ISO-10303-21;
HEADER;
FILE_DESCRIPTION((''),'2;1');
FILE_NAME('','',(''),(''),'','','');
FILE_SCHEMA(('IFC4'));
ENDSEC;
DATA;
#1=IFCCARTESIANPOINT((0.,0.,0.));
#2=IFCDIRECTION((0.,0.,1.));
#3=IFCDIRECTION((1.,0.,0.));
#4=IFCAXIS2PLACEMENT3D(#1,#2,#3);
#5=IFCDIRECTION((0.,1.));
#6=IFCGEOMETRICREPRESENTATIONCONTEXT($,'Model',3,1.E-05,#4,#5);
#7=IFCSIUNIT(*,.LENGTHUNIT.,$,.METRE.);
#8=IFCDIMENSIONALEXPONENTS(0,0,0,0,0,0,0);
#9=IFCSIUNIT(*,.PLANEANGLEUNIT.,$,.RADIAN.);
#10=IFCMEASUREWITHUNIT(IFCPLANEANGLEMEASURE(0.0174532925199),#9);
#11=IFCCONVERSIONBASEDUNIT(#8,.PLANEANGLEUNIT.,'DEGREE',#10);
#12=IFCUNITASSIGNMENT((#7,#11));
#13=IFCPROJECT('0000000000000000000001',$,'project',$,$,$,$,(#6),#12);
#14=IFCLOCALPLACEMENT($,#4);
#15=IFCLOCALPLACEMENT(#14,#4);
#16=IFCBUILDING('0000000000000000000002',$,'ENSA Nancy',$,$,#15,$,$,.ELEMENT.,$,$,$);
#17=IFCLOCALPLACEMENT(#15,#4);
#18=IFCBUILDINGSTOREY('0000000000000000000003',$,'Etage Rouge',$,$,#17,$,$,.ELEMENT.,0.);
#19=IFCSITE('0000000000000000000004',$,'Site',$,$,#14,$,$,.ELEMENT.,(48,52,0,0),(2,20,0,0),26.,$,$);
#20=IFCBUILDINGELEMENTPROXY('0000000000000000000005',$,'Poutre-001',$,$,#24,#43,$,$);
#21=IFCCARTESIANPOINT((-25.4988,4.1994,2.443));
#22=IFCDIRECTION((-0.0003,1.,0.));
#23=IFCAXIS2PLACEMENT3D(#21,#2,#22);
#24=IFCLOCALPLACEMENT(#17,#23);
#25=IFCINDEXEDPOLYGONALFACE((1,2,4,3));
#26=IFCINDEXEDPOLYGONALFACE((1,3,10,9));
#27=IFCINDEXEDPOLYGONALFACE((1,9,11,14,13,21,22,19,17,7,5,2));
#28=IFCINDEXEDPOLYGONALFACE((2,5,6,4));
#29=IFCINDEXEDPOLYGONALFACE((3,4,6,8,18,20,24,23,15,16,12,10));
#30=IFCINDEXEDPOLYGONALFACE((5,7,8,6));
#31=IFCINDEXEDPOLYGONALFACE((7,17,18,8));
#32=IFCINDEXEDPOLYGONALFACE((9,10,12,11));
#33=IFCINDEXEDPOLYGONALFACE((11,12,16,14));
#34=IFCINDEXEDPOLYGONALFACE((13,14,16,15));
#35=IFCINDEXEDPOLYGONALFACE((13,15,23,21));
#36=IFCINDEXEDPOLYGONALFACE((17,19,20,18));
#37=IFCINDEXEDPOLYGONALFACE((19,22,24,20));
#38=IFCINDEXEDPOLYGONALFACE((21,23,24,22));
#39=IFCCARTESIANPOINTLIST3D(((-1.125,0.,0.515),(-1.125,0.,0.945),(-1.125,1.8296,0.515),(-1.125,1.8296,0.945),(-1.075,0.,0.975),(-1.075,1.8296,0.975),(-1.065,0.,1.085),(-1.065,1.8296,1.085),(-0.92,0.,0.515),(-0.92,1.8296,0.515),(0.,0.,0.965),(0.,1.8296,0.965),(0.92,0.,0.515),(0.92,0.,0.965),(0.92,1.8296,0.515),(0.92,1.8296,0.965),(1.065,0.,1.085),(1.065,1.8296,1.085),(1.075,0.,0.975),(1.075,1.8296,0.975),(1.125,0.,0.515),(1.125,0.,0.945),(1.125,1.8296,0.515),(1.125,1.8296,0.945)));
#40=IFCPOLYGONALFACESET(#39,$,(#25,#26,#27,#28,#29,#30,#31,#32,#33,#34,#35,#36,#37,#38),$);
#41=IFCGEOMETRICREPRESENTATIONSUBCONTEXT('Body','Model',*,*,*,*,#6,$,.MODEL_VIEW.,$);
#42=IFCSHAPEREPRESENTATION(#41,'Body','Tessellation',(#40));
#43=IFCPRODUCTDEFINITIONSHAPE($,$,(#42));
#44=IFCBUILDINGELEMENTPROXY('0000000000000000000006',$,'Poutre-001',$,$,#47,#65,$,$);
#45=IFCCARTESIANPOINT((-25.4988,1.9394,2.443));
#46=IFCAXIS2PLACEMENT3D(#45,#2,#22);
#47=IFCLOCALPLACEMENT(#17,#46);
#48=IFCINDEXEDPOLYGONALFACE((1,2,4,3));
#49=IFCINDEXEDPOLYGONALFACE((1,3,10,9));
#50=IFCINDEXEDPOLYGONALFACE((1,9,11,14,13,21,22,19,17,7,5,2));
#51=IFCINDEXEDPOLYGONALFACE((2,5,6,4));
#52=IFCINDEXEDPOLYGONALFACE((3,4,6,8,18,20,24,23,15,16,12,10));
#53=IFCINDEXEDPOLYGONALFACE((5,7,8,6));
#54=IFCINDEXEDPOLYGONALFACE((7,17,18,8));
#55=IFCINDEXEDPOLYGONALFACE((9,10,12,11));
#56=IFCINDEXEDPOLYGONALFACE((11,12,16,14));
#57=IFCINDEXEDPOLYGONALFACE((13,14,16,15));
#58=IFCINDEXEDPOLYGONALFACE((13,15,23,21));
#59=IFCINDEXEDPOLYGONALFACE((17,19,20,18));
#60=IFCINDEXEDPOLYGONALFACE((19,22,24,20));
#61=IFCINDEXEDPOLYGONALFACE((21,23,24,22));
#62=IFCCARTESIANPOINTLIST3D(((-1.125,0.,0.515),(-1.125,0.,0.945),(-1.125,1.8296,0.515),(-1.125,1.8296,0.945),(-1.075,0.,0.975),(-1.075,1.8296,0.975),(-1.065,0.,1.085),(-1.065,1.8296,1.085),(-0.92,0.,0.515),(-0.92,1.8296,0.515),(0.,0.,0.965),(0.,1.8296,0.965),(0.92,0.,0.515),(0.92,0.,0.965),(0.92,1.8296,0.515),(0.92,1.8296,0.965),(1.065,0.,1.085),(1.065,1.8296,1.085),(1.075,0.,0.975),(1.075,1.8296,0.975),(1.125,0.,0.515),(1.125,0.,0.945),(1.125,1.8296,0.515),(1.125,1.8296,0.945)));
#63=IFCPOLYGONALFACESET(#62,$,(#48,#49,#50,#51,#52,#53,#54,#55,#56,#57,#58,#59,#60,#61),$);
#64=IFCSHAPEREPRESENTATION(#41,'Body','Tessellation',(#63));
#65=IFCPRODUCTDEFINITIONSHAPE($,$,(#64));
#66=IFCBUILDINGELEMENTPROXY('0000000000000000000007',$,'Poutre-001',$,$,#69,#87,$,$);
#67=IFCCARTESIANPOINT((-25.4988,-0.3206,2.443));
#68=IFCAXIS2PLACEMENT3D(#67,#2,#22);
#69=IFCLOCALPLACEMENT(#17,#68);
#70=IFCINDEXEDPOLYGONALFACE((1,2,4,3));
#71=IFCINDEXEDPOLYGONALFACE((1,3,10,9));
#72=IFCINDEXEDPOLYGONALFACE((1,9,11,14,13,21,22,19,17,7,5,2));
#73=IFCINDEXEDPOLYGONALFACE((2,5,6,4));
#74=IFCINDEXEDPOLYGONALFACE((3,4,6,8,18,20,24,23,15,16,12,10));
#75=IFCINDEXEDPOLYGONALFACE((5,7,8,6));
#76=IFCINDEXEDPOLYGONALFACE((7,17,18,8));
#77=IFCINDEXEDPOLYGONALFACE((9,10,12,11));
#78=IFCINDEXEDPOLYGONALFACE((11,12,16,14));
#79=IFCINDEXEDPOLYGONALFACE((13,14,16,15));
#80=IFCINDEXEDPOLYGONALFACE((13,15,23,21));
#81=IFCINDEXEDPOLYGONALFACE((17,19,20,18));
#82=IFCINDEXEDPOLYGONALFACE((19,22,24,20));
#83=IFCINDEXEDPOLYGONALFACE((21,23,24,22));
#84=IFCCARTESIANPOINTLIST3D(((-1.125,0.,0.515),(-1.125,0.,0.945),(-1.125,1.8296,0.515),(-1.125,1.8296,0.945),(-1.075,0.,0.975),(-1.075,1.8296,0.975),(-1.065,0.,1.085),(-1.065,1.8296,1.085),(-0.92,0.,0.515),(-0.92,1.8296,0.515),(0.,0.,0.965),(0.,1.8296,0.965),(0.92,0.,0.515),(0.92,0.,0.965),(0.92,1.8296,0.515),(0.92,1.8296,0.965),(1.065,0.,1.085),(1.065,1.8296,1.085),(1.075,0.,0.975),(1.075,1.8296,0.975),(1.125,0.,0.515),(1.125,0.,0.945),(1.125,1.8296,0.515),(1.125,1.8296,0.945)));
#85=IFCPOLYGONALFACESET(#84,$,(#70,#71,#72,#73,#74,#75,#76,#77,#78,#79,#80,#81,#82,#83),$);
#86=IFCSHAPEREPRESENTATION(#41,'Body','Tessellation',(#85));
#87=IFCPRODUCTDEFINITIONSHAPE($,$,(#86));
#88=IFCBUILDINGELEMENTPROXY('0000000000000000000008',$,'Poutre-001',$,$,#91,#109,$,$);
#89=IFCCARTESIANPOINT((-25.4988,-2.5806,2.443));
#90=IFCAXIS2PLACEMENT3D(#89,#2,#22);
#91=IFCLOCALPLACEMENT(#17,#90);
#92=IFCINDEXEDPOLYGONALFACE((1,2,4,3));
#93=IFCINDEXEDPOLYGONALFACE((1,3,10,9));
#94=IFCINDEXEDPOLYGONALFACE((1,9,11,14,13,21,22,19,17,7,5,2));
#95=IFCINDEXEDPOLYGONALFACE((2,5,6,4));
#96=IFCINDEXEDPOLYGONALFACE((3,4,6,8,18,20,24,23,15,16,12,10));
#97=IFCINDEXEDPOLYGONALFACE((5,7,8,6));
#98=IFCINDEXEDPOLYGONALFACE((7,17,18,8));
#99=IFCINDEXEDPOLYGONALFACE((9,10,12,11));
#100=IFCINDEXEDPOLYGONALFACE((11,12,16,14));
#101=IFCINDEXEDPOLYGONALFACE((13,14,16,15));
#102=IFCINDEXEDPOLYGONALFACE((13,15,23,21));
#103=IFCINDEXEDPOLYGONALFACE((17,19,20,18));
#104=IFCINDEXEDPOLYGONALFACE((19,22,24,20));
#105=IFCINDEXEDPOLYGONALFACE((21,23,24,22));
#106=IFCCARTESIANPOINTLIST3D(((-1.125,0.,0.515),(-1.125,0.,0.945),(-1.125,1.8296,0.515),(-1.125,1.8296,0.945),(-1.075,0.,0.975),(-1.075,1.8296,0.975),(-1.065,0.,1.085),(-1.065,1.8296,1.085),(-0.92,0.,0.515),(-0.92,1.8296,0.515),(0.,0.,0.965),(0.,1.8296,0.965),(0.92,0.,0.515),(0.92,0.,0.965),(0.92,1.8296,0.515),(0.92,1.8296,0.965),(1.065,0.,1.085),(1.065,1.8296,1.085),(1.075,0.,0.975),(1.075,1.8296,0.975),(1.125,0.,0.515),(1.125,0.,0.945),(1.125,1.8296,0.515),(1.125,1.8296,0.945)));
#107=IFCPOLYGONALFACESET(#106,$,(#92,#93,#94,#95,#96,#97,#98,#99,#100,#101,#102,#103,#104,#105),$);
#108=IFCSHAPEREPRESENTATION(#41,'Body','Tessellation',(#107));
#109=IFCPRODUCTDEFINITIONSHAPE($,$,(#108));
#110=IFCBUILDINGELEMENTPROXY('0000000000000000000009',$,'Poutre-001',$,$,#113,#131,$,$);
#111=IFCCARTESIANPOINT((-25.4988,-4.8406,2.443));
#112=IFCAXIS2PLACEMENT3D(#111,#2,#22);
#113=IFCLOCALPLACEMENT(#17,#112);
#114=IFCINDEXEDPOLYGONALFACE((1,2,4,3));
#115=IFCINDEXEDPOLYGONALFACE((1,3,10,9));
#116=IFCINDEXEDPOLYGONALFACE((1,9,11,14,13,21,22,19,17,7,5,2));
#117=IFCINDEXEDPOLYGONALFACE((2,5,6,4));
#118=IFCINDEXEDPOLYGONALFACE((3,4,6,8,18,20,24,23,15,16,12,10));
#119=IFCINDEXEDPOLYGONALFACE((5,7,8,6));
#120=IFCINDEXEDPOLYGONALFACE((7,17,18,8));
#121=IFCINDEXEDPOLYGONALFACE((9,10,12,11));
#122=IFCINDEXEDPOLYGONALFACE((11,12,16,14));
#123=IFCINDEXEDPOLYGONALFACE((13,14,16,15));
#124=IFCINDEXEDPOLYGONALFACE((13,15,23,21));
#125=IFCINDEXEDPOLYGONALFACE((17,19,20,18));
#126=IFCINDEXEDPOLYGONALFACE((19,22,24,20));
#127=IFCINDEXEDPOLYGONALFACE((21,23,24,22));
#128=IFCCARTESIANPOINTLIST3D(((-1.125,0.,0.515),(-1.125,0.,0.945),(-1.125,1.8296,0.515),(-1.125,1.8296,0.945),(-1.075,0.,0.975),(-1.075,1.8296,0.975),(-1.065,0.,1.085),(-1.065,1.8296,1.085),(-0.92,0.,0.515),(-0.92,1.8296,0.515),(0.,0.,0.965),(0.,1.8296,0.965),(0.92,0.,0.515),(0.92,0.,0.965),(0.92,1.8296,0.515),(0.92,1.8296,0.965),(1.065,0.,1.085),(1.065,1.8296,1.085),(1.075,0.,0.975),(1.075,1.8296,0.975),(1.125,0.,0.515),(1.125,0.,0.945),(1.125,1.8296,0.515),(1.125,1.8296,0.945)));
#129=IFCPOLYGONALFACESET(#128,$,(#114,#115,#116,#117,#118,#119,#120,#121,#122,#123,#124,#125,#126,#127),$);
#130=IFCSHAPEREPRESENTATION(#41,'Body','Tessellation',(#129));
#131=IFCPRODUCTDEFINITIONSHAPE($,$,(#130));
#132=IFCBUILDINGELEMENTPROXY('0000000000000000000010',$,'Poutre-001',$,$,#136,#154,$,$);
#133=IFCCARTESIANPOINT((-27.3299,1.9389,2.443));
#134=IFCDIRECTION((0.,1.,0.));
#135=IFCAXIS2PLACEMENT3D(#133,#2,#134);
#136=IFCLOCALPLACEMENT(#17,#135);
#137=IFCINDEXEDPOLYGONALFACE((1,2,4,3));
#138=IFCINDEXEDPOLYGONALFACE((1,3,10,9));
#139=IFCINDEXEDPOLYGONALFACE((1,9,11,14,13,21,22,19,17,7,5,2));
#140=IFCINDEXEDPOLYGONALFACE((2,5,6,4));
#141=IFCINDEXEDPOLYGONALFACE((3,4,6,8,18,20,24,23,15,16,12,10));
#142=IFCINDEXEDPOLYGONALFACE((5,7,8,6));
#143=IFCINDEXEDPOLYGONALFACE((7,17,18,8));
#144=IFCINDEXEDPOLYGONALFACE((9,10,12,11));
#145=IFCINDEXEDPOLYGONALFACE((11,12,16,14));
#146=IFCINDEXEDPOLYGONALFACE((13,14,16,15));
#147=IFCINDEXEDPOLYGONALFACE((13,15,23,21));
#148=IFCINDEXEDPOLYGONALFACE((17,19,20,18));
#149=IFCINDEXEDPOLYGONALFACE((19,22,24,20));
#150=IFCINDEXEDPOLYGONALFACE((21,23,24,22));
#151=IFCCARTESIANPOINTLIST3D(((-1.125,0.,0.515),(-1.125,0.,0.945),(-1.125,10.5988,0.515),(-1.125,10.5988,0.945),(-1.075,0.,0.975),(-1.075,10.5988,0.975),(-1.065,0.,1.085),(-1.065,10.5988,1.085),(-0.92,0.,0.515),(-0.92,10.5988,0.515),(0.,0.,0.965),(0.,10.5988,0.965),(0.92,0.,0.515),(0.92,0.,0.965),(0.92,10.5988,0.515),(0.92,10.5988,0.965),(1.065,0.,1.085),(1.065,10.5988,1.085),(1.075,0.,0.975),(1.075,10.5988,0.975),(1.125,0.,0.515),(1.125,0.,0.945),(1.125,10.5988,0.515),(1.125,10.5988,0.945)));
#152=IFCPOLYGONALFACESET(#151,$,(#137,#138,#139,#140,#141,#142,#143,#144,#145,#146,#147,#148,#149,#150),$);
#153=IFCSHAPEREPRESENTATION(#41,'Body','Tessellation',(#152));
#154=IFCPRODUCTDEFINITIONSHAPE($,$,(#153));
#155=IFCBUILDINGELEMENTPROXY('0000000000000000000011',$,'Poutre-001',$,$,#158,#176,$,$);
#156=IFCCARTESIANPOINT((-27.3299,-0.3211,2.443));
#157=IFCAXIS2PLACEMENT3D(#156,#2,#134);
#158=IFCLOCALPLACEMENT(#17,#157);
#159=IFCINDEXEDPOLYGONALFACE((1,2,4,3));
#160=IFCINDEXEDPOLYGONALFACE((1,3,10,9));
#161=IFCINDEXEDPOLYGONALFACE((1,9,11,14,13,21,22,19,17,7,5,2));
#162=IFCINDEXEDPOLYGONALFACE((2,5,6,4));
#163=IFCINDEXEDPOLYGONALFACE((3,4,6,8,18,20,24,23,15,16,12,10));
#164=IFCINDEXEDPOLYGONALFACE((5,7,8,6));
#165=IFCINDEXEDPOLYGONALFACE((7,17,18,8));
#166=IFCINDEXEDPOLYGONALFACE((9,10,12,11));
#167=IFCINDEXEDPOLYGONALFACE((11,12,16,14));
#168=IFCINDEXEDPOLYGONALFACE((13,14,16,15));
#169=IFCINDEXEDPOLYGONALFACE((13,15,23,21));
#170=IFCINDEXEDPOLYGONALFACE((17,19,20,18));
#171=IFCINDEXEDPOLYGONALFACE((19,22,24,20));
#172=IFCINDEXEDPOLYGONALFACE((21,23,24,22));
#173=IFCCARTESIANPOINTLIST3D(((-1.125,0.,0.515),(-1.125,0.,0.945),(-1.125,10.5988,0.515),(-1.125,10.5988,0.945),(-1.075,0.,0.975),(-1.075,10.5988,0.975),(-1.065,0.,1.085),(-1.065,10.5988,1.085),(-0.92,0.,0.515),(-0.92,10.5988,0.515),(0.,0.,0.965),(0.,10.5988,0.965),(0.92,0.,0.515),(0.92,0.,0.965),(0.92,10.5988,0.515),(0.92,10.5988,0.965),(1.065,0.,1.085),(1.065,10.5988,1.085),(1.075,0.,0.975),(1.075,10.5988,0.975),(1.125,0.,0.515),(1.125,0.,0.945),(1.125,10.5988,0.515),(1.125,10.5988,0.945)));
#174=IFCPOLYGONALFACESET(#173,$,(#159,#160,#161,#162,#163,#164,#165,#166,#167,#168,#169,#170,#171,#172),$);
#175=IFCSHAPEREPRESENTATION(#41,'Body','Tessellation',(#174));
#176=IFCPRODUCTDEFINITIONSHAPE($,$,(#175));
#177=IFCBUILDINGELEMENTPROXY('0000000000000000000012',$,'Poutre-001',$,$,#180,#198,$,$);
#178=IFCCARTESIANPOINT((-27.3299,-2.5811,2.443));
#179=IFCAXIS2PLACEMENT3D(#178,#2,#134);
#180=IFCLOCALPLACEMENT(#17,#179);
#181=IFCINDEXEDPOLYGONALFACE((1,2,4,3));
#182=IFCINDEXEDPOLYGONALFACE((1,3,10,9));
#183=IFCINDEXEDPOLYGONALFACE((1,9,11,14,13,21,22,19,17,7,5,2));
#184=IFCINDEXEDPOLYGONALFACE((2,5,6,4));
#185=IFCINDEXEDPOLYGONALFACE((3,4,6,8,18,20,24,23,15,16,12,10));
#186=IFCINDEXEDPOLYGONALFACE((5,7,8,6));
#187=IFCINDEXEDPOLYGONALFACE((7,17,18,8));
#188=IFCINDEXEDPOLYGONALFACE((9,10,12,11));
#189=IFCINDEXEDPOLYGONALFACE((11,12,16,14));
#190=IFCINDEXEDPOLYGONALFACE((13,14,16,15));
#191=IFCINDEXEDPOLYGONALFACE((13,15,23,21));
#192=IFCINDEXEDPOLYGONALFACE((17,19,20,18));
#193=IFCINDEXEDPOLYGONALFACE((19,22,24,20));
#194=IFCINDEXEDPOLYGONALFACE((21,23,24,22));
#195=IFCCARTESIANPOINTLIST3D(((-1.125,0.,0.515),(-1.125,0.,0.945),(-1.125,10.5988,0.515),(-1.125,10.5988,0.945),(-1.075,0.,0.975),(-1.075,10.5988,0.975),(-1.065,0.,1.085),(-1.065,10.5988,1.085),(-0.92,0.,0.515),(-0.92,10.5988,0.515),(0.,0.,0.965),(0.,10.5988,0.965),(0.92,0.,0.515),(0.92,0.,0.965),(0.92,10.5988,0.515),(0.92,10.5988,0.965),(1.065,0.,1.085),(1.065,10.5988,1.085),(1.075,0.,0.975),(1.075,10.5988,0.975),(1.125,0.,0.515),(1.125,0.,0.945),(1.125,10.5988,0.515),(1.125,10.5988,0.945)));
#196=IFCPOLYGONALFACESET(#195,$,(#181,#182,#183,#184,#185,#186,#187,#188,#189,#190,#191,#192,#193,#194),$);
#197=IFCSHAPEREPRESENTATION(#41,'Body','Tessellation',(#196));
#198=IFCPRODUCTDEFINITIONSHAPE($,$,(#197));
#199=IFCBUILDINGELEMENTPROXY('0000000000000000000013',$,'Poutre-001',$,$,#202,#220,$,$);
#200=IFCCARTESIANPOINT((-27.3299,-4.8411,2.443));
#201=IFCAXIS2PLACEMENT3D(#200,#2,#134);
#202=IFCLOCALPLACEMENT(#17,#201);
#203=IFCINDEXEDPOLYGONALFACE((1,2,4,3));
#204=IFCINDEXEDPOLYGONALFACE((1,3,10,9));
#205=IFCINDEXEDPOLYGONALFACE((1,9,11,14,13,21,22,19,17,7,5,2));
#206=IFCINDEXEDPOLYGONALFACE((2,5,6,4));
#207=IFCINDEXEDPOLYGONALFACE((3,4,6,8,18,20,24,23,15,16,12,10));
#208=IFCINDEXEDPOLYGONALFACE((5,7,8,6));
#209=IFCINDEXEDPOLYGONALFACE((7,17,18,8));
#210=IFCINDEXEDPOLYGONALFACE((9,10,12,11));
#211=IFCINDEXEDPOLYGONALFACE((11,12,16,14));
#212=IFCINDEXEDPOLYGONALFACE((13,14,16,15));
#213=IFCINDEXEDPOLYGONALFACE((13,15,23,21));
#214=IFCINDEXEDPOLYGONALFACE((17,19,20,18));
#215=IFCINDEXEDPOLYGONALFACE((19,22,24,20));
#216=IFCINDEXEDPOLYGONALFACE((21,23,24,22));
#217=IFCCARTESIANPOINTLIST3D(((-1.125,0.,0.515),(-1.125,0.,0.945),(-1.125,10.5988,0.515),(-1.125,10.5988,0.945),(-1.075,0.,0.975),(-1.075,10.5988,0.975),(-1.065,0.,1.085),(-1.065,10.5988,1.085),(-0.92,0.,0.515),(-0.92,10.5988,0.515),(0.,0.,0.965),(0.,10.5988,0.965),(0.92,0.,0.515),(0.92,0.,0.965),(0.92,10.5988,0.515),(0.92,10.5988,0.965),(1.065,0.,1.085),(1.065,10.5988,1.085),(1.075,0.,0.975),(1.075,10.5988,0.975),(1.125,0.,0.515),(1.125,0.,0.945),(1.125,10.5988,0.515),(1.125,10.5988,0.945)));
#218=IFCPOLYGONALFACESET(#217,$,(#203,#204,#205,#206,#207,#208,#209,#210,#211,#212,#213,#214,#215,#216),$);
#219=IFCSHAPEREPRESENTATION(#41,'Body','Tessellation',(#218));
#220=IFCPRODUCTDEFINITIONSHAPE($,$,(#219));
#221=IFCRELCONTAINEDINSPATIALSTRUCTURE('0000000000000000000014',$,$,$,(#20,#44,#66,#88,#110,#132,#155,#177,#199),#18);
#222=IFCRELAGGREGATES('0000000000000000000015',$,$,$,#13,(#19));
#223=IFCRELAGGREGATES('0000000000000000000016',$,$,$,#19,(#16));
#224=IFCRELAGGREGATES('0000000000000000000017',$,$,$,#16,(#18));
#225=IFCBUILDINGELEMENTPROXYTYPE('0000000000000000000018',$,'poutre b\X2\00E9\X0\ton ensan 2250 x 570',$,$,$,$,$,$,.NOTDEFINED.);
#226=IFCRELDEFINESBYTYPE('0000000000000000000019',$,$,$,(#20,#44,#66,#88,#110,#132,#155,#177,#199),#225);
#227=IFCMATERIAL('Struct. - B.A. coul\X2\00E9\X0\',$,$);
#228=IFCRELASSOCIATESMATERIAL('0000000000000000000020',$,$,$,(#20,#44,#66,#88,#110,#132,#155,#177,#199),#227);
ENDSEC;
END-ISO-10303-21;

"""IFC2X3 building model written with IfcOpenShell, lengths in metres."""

from ifc_helpers import new_model, entity, si_unit, converted_unit, direction, frame, origin_with_axes, place, context, subcontext, project, spatial, polyline, outline, extrude, material, type_object, element, save


model = new_model("IFC2X3")

# Units and contexts
model_context = context("Model", 3, precision=1e-05, world=origin_with_axes(), true_north=direction((0.0, 1.0)))
body_context = subcontext(model_context, "Body", "Model", "MODEL_VIEW")
ifc_project = project(units=[si_unit("LENGTHUNIT", "METRE"), converted_unit("PLANEANGLEUNIT", "DEGREE", entity("IfcPlaneAngleMeasure", 0.0174532925199), si_unit("PLANEANGLEUNIT", "RADIAN"), dimensions=[0, 0, 0, 0, 0, 0, 0])], contexts=[model_context])

# Site, building, storey
site_placement = place(None, origin_with_axes())
site = spatial("IfcSite", under=ifc_project, at=site_placement, Name="Site", CompositionType="ELEMENT", RefLatitude=(48, 52, 0, 0), RefLongitude=(2, 20, 0, 0), RefElevation=26.0)
building_placement = place(site_placement, origin_with_axes())
building = spatial("IfcBuilding", under=site, at=building_placement, Name="ENSA Nancy", CompositionType="ELEMENT")
storey_placement = place(building_placement, origin_with_axes())
storey = spatial("IfcBuildingStorey", under=building, at=storey_placement, Name="Etage Rouge", CompositionType="ELEMENT", Elevation=0.0)

# Building element proxies
ifc_material_1 = material(Name="Struct. - B.A. coulé")
building_element_proxy_type_1 = type_object("IfcBuildingElementProxyType", Name="poutre béton ensan 2250 x 570", PredefinedType="NOTDEFINED")
for number, where, z_axis, x_axis, name in (
    (1, (-25.4988, 4.1994, 2.443), (0.0, 0.0, 1.0), (-0.0003, 1.0, 0.0), "Poutre-001"),
    (2, (-25.4988, 1.9394, 2.443), (0.0, 0.0, 1.0), (-0.0003, 1.0, 0.0), "Poutre-001"),
    (3, (-25.4988, -0.3206, 2.443), (0.0, 0.0, 1.0), (-0.0003, 1.0, 0.0), "Poutre-001"),
    (4, (-25.4988, -2.5806, 2.443), (0.0, 0.0, 1.0), (-0.0003, 1.0, 0.0), "Poutre-001"),
    (5, (-25.4988, -4.8406, 2.443), (0.0, 0.0, 1.0), (-0.0003, 1.0, 0.0), "Poutre-001"),
):
    element("IfcBuildingElementProxy", number, at=place(storey_placement, frame(where, z_axis=z_axis, x_axis=x_axis)), inside=storey, type_object=building_element_proxy_type_1, material=ifc_material_1, Name=name, context=body_context, shape_type="SweptSolid", body=[
        extrude(outline(polyline([(-1.065, 1.085), (-1.075, 0.975), (-1.125, 0.945), (-1.125, 0.515), (-0.92, 0.515), (0.0, 0.965), (0.92, 0.965), (0.92, 0.515), (1.125, 0.515), (1.125, 0.945), (1.075, 0.975), (1.065, 1.085), (-1.065, 1.085)])), frame((0.0, 1.8296, 0.0), z_axis=(0.0, -1.0, 0.0), x_axis=(1.0, 0.0, 0.0)), (0.0, 0.0, 1.0), 1.8296),
    ])
for number, where, z_axis, x_axis, name in (
    (6, (-27.3299, 1.9389, 2.443), (0.0, 0.0, 1.0), (0.0, 1.0, 0.0), "Poutre-001"),
    (7, (-27.3299, -0.3211, 2.443), (0.0, 0.0, 1.0), (0.0, 1.0, 0.0), "Poutre-001"),
    (8, (-27.3299, -2.5811, 2.443), (0.0, 0.0, 1.0), (0.0, 1.0, 0.0), "Poutre-001"),
    (9, (-27.3299, -4.8411, 2.443), (0.0, 0.0, 1.0), (0.0, 1.0, 0.0), "Poutre-001"),
):
    element("IfcBuildingElementProxy", number, at=place(storey_placement, frame(where, z_axis=z_axis, x_axis=x_axis)), inside=storey, type_object=building_element_proxy_type_1, material=ifc_material_1, Name=name, context=body_context, shape_type="SweptSolid", body=[
        extrude(outline(polyline([(-1.065, 1.085), (-1.075, 0.975), (-1.125, 0.945), (-1.125, 0.515), (-0.92, 0.515), (0.0, 0.965), (0.92, 0.965), (0.92, 0.515), (1.125, 0.515), (1.125, 0.945), (1.075, 0.975), (1.065, 1.085), (-1.065, 1.085)])), frame((0.0, 10.5988, 0.0), z_axis=(0.0, -1.0, 0.0), x_axis=(1.0, 0.0, 0.0)), (0.0, 0.0, 1.0), 10.5988),
    ])

save(model, "model.ifc")
